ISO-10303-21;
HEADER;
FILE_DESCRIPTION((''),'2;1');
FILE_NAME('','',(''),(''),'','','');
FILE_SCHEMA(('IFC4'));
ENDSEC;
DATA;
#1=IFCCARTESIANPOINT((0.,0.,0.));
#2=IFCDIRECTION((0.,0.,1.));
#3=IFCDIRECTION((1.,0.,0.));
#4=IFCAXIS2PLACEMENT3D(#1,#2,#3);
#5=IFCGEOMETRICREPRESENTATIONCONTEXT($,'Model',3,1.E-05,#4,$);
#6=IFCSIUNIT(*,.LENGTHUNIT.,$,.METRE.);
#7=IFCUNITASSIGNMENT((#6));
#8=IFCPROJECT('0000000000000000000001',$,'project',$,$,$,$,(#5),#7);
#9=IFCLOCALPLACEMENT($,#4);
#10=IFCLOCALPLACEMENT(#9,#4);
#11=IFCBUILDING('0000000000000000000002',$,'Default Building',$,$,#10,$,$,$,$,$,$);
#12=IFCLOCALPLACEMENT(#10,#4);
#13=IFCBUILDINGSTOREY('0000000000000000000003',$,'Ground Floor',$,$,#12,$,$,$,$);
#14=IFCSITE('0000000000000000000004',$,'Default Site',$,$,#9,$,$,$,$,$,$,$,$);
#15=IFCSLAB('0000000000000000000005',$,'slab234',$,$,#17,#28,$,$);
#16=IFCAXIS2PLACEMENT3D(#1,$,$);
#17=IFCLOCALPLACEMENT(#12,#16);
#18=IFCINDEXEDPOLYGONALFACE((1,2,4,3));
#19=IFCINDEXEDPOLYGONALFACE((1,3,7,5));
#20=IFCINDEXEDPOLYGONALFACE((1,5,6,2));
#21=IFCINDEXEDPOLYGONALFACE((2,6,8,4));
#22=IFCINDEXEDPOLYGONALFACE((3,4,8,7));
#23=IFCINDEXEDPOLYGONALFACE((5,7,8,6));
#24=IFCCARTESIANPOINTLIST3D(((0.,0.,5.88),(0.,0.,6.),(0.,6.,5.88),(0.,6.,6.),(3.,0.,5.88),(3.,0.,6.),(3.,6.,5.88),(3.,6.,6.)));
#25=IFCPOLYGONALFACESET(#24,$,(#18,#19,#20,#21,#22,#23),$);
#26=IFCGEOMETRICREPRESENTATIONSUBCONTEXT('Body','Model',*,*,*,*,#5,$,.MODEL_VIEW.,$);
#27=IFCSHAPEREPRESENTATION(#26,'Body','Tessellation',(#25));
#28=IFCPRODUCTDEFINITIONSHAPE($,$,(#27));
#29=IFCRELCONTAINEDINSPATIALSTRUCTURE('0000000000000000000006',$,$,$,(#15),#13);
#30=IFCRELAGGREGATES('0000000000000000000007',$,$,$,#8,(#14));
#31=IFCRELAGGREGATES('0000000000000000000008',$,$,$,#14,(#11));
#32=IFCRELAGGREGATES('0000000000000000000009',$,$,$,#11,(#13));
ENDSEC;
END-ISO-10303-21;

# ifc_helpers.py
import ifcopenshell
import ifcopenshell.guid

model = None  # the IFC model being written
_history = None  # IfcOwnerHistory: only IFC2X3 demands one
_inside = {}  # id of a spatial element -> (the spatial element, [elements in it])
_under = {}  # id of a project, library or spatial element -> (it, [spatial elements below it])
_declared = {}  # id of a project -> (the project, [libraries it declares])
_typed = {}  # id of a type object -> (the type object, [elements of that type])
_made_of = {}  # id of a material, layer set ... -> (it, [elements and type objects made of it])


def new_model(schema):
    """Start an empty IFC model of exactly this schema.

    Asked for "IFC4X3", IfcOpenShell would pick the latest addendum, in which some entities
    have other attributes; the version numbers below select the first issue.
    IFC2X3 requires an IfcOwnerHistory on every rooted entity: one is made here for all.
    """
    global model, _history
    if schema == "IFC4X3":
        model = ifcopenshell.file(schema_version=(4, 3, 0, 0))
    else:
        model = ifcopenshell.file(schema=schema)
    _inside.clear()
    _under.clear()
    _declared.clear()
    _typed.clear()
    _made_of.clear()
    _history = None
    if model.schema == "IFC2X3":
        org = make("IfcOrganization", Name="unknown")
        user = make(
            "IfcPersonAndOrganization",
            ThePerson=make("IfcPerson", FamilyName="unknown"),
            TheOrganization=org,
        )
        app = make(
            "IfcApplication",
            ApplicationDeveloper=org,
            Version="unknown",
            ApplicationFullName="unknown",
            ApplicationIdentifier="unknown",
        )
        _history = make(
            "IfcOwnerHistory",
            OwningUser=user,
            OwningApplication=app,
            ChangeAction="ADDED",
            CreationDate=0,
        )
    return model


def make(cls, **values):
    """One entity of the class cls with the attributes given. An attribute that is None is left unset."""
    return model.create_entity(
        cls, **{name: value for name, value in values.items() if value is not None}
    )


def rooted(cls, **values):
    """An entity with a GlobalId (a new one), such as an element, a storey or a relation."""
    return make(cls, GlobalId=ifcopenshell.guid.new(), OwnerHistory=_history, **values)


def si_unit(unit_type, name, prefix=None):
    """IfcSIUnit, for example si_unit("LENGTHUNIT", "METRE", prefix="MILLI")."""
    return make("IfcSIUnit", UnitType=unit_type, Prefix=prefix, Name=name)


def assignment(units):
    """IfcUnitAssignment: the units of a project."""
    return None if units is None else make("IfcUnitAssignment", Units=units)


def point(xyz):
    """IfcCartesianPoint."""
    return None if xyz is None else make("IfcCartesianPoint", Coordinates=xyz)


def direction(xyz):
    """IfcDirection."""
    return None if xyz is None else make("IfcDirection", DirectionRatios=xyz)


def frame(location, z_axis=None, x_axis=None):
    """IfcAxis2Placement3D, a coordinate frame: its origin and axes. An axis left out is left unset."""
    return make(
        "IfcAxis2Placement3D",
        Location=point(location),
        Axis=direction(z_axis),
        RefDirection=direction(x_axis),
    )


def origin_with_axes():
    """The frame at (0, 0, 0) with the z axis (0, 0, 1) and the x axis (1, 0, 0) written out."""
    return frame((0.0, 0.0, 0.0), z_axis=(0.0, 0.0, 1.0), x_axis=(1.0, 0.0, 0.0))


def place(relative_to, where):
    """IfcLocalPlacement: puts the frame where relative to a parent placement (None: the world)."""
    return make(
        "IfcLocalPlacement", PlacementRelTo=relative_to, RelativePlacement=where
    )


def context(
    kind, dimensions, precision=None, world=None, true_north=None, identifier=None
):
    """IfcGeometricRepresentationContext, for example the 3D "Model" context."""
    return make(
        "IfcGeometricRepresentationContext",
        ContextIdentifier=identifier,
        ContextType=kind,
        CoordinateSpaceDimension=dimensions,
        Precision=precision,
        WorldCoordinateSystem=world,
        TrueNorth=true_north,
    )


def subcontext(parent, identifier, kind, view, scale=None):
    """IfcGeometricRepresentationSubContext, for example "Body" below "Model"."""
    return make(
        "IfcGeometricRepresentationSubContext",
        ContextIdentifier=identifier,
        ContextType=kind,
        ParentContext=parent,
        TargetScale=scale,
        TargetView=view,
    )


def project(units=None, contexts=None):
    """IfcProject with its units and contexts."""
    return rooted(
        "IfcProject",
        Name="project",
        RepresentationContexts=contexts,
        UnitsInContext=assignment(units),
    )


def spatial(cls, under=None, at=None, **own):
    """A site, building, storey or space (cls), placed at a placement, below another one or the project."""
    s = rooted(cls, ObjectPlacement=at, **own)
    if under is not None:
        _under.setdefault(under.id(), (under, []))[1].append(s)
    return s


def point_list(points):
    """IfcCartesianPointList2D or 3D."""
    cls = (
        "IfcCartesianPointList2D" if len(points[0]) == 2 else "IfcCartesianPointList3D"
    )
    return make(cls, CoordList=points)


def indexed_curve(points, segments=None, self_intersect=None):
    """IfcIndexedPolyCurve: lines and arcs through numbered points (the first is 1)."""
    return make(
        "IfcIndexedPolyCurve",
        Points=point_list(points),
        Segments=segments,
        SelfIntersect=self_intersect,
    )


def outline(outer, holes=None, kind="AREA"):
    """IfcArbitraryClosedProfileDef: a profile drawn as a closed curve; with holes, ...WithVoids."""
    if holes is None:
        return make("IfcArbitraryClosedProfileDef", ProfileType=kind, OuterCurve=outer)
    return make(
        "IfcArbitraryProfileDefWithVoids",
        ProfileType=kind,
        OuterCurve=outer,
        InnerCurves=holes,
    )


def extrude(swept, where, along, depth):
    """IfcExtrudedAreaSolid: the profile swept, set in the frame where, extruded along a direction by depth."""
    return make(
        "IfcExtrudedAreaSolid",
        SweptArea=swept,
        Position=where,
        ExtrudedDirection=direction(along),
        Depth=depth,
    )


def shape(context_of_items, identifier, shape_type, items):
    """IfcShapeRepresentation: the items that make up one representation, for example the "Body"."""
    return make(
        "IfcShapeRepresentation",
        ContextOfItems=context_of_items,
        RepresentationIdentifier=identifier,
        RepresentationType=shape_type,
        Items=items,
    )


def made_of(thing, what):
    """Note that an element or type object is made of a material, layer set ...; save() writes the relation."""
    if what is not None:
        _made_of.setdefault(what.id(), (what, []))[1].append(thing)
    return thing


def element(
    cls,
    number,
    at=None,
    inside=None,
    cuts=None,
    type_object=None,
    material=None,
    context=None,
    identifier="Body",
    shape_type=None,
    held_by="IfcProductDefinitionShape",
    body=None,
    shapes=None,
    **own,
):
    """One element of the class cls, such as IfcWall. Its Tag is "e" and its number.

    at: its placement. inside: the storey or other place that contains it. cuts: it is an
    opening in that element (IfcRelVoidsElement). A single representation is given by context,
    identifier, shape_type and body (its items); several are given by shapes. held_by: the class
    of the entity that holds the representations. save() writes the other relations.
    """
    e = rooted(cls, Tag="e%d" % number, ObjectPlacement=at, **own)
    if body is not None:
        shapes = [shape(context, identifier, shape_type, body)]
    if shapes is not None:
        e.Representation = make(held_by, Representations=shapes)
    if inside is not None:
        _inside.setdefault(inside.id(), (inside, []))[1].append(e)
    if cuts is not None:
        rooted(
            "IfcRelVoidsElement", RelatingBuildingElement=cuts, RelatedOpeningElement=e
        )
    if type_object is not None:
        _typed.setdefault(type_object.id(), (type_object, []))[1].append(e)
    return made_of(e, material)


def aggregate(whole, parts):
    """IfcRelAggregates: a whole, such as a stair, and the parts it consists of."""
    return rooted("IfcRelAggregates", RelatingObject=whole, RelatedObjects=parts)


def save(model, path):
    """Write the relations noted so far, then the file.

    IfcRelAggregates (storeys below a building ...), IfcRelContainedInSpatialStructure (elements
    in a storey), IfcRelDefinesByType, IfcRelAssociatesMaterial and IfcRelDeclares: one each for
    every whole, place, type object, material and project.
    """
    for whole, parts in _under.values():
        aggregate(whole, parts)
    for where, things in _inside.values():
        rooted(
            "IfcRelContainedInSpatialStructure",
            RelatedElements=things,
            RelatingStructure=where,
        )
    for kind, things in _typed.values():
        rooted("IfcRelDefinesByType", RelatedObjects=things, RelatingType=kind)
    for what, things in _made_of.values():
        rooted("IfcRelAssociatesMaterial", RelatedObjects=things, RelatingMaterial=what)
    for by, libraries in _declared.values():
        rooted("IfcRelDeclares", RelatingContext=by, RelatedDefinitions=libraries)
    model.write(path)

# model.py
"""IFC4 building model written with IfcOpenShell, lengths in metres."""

from ifc_helpers import new_model, si_unit, frame, origin_with_axes, place, context, subcontext, project, spatial, indexed_curve, outline, extrude, element, save


model = new_model("IFC4")

# Units and contexts
model_context = context("Model", 3, precision=1e-05, world=origin_with_axes())
body_context = subcontext(model_context, "Body", "Model", "MODEL_VIEW")
ifc_project = project(units=[si_unit("LENGTHUNIT", "METRE")], contexts=[model_context])

# Site, building, storey
site_placement = place(None, origin_with_axes())
site = spatial("IfcSite", under=ifc_project, at=site_placement, Name="Default Site")
building_placement = place(site_placement, origin_with_axes())
building = spatial("IfcBuilding", under=site, at=building_placement, Name="Default Building")
storey_placement = place(building_placement, origin_with_axes())
storey = spatial("IfcBuildingStorey", under=building, at=storey_placement, Name="Ground Floor")

# Slab
for number, where, z_axis, x_axis, name in (
    (1, (0.0, 0.0, 5.88), (0.0, 0.0, 1.0), (1.0, 0.0, 0.0), "slab234"),
):
    element("IfcSlab", number, at=place(storey_placement, frame(where, z_axis=z_axis, x_axis=x_axis)), inside=storey, Name=name, context=body_context, shape_type="SweptSolid", body=[
        extrude(outline(indexed_curve([(0.0, 0.0), (0.0, 6.0), (3.0, 6.0), (3.0, 0.0), (0.0, 0.0)], self_intersect=False)), origin_with_axes(), (0.0, 0.0, 1.0), 0.12),
    ])

save(model, "model.ifc")
